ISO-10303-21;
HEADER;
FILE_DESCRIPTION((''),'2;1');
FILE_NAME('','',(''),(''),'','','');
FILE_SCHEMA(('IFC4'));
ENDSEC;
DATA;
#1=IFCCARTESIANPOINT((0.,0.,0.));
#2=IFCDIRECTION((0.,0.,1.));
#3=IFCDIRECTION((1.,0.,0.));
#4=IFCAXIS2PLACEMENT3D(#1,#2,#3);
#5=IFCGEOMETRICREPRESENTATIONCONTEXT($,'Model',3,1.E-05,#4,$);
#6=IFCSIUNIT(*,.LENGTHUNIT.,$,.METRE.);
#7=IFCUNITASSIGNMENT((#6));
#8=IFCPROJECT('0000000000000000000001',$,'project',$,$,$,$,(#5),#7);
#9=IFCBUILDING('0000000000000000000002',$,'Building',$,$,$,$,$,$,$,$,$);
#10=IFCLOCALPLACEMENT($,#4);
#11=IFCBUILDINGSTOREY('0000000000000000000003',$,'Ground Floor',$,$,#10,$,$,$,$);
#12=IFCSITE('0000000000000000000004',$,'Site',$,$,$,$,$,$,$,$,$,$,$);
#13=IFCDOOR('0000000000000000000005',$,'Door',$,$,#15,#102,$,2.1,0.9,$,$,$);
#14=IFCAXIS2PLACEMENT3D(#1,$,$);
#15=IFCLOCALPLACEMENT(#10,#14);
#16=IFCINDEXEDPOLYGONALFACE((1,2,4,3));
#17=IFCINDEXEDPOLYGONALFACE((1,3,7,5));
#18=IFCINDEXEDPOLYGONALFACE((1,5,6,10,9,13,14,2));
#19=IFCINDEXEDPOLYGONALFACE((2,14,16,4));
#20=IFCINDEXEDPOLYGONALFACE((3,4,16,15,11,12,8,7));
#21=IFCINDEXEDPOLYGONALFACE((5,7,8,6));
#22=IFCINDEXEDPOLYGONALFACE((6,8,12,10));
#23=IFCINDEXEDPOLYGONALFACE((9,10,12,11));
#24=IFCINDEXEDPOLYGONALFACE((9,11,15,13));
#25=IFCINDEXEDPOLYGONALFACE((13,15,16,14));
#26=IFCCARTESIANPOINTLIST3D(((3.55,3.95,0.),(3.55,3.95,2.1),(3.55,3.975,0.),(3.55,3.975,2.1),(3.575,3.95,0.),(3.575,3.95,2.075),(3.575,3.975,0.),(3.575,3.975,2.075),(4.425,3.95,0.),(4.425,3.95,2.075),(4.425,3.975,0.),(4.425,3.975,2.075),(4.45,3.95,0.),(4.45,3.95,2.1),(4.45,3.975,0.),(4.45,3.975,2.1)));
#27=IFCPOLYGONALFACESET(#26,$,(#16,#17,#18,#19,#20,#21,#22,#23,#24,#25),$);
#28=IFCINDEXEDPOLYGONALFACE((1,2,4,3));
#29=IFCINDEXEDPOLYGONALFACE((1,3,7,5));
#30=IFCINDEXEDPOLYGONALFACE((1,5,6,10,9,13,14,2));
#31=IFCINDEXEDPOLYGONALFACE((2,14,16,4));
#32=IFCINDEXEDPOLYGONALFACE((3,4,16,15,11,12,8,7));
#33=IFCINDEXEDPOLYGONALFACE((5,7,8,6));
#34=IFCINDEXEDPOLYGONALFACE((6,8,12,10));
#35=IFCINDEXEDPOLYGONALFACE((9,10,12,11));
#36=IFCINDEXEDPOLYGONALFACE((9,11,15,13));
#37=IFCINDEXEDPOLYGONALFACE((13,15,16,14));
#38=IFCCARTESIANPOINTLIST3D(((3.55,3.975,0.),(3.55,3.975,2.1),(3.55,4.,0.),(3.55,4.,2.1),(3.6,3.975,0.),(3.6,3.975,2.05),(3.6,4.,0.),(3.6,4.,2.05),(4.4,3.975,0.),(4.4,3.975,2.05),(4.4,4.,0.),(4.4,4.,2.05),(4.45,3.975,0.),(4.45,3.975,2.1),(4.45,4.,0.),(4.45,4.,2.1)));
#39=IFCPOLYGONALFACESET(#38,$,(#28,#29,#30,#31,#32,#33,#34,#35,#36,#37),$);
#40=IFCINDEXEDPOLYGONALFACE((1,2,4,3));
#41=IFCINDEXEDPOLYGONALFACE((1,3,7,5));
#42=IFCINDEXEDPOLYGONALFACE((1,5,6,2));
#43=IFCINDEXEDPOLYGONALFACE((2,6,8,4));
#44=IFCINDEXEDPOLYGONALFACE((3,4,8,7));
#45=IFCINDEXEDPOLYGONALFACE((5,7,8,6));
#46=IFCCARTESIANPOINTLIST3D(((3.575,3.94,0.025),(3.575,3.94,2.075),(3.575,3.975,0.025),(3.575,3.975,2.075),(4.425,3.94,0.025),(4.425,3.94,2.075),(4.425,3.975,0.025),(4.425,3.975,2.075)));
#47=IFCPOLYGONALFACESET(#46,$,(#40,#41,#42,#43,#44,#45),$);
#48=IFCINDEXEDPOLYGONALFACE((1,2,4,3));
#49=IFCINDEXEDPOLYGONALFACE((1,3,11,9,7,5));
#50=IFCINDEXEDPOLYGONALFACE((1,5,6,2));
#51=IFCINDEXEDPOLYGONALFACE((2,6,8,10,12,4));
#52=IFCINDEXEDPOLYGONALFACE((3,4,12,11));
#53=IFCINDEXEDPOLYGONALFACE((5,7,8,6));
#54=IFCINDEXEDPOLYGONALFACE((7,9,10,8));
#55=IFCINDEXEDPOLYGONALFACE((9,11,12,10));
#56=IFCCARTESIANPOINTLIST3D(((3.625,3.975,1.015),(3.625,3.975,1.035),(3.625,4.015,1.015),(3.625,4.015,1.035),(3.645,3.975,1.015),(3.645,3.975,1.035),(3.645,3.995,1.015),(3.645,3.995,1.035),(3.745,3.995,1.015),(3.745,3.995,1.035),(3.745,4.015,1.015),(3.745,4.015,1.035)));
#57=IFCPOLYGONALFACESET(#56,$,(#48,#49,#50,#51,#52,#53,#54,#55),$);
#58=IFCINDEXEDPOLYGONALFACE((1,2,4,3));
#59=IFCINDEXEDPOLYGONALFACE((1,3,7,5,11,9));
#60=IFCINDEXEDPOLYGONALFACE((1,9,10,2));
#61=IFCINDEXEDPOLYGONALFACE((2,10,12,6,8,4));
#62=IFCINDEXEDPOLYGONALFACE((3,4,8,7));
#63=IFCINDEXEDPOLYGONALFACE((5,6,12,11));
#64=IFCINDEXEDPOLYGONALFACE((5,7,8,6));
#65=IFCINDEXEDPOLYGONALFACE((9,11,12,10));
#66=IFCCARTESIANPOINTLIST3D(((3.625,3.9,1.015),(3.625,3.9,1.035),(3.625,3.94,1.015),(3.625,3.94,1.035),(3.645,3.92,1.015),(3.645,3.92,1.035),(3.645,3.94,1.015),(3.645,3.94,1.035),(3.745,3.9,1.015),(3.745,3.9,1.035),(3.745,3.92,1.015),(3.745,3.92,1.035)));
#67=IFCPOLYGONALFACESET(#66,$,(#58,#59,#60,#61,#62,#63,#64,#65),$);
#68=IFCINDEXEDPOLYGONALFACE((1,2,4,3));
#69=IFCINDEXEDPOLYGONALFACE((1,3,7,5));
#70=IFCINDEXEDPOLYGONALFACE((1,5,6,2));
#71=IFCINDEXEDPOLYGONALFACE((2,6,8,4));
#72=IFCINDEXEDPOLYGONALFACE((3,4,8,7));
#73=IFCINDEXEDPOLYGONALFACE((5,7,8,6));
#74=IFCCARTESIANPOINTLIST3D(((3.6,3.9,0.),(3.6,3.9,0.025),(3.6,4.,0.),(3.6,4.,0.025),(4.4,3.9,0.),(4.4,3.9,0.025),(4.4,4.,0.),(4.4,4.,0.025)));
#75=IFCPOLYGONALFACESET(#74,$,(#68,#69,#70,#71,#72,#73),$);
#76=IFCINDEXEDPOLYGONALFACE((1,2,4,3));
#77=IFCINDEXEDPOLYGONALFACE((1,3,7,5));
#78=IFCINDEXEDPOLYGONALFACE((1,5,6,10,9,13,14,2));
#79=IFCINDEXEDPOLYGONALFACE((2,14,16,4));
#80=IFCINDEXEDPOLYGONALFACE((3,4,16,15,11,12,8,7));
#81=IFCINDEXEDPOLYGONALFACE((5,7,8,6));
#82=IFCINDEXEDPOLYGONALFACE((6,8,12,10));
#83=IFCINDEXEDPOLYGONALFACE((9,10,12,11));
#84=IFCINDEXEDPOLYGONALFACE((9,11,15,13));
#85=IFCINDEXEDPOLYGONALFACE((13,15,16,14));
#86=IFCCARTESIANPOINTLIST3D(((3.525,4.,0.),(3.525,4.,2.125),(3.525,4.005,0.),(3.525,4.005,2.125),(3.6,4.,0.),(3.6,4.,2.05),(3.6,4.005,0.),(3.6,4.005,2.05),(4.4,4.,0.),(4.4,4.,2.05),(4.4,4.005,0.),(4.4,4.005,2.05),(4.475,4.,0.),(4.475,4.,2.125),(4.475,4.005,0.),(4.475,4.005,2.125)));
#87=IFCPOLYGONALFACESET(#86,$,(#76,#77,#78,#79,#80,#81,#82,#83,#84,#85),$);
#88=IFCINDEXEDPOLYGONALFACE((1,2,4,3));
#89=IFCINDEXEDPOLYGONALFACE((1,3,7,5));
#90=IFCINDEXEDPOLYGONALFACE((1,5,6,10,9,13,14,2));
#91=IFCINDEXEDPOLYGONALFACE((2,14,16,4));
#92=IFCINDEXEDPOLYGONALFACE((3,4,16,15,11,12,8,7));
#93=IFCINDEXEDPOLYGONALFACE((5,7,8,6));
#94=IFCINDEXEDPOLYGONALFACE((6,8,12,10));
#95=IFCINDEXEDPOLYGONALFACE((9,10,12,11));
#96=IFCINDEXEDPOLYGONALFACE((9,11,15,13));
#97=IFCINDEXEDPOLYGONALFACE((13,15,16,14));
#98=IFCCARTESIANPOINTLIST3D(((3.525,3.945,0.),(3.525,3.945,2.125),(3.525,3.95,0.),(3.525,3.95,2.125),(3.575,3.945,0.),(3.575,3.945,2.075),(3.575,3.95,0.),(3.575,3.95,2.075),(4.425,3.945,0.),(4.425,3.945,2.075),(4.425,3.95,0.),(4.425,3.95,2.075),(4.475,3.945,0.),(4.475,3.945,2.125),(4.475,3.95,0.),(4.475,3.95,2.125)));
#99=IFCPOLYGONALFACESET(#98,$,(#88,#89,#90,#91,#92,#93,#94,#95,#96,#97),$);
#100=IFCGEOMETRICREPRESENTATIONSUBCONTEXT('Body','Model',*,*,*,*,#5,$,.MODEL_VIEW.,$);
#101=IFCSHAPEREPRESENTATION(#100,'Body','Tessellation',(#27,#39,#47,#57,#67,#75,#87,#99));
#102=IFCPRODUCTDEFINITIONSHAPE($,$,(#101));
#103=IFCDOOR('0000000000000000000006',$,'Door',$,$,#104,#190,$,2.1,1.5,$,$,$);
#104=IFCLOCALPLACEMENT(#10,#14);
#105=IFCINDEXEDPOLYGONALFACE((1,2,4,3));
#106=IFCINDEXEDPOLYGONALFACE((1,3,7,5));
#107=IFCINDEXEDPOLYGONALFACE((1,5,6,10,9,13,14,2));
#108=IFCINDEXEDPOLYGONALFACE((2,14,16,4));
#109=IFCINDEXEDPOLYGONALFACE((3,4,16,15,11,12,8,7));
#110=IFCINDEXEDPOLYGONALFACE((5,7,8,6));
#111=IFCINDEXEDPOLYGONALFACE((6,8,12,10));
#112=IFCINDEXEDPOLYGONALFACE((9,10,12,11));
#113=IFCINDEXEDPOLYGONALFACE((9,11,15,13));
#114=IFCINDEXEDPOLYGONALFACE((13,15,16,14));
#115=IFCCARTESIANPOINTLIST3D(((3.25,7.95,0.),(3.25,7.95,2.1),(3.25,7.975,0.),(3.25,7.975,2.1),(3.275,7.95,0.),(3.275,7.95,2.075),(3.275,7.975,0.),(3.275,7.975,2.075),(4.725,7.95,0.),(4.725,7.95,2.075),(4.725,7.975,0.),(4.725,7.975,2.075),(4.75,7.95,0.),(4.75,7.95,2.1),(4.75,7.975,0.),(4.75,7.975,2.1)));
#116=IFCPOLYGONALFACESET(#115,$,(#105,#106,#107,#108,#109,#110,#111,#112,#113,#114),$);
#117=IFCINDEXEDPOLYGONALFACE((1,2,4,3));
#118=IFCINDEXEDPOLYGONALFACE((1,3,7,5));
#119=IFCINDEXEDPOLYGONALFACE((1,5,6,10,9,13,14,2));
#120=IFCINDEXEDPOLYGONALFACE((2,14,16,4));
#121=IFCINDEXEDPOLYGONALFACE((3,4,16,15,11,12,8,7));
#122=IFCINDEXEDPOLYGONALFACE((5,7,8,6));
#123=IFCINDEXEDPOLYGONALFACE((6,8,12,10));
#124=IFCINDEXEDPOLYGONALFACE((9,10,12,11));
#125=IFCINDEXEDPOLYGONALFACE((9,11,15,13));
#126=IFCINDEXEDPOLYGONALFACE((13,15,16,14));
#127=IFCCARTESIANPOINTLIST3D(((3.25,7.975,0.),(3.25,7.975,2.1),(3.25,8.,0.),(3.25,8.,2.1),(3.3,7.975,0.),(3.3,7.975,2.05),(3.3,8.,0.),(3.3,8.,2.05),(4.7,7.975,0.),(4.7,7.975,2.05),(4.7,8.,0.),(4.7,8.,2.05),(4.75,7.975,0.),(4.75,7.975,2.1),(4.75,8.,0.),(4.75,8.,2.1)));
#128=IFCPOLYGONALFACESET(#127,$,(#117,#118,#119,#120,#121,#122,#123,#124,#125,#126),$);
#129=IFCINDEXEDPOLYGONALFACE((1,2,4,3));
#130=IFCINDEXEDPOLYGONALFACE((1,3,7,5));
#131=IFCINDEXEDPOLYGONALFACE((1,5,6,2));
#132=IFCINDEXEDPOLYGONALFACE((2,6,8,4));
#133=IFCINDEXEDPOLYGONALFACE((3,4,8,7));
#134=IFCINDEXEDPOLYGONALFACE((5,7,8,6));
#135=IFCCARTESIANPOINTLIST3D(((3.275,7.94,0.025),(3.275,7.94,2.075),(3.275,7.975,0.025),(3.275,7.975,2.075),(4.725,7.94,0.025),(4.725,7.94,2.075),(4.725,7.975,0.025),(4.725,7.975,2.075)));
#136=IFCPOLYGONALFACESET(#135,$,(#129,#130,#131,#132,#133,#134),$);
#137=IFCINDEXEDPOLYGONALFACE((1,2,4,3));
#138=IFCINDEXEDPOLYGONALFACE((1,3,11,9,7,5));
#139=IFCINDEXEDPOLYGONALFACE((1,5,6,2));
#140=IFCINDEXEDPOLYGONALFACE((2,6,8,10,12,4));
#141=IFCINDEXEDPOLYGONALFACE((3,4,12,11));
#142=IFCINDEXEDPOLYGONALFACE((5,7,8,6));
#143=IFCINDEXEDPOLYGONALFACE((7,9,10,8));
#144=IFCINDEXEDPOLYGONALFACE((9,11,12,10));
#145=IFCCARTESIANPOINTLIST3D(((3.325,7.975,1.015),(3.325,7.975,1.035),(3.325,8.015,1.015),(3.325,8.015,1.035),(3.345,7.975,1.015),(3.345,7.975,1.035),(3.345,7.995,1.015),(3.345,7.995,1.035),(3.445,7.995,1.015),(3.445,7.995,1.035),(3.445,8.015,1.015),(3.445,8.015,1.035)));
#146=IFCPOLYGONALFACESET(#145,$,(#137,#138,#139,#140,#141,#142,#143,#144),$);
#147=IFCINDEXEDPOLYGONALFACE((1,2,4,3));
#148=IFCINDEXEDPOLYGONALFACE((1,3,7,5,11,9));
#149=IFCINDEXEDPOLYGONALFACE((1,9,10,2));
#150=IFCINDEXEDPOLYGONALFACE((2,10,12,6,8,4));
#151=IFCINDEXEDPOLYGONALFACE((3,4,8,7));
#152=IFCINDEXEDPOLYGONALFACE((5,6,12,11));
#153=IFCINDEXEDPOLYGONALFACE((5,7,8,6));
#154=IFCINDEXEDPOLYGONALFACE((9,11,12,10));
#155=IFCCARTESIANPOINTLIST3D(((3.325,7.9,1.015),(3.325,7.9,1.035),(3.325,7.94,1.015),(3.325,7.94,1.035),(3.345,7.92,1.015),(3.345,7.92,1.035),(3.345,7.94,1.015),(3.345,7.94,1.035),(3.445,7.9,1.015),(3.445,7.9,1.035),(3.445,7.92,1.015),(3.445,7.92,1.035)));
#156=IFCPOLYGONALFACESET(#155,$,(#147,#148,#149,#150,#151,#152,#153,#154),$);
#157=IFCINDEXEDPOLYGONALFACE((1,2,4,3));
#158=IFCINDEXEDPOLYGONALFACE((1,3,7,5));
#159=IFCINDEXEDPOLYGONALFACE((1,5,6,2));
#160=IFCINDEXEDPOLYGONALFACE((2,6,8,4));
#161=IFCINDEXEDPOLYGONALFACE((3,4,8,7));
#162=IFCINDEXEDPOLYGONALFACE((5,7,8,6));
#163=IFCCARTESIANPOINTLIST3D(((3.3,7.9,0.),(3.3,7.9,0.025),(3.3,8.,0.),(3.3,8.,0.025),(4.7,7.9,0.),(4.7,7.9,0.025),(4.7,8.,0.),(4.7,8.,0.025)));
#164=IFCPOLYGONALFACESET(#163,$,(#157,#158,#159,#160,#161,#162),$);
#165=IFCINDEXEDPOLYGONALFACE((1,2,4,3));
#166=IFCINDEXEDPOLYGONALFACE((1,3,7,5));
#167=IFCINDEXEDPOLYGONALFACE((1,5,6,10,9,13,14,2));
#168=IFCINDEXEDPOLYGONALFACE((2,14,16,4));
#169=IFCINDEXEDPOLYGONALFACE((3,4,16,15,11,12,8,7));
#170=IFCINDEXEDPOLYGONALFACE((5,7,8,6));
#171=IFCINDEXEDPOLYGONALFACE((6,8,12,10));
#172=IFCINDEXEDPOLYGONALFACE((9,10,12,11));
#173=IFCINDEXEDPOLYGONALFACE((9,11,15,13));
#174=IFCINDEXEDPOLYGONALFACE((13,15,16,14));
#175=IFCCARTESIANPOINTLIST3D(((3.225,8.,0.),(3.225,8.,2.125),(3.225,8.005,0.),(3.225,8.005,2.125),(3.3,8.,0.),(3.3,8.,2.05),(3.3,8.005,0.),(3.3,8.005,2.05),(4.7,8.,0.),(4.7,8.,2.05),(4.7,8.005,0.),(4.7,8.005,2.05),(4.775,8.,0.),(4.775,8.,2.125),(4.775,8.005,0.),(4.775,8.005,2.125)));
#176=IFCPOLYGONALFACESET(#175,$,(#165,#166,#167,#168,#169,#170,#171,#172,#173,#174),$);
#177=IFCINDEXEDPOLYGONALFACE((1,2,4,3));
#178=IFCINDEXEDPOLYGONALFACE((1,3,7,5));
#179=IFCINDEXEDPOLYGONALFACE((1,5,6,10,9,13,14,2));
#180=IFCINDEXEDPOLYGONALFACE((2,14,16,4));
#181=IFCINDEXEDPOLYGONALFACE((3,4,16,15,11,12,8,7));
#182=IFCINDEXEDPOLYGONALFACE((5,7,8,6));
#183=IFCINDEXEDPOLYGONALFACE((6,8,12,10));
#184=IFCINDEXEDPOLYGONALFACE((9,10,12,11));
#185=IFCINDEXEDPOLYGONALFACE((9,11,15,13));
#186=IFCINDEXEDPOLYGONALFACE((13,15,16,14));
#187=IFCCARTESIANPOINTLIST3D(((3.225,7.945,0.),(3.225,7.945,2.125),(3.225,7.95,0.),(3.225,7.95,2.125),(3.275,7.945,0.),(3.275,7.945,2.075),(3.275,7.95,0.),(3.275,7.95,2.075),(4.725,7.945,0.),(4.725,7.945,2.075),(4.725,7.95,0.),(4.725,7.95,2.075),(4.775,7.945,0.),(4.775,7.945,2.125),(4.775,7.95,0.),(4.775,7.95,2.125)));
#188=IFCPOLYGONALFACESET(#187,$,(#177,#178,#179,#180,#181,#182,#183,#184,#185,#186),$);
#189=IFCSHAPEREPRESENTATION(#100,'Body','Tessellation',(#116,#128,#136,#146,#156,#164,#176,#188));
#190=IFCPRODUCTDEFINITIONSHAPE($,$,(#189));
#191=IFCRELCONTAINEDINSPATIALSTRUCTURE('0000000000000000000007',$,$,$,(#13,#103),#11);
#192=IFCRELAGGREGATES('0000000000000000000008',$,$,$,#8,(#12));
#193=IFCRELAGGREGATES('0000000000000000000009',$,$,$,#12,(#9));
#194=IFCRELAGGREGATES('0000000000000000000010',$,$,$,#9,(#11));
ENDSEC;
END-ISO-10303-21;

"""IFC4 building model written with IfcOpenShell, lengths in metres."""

from ifc_helpers import new_model, si_unit, frame, origin_with_axes, place, context, subcontext, project, spatial, line, indexed_curve, outline, extrude, element, save


model = new_model("IFC4")

# Units and contexts
model_context = context("Model", 3, precision=1e-05, world=origin_with_axes())
body_context = subcontext(model_context, "Body", "Model", "MODEL_VIEW")
ifc_project = project(units=[si_unit("LENGTHUNIT", "METRE")], contexts=[model_context])

# Site, building, storey
site = spatial("IfcSite", under=ifc_project, Name="Site")
building = spatial("IfcBuilding", under=site, Name="Building")
storey_placement = place(None, origin_with_axes())
storey = spatial("IfcBuildingStorey", under=building, at=storey_placement, Name="Ground Floor")

# Doors
door_1_placement = place(storey_placement, frame((4.45, 4.0, 0.0), z_axis=(0.0, 0.0, 1.0), x_axis=(-1.0, 0.0, 0.0)))
element("IfcDoor", 1, at=door_1_placement, inside=storey, Name="Door", OverallHeight=2.1, OverallWidth=0.9, context=body_context, shape_type="SweptSolid", body=[
    extrude(outline(indexed_curve([(0.0, 0.0), (0.0, 2.1), (0.9, 2.1), (0.9, 0.0), (0.875, 0.0), (0.875, 2.075), (0.025, 2.075), (0.025, 0.0)], segments=[line(1, 2, 3, 4, 5, 6, 7, 8, 1)])), frame((0.0, 0.025, 0.0), z_axis=(0.0, -1.0, 0.0), x_axis=(1.0, 0.0, 0.0)), (0.0, 0.0, -1.0), 0.025),
    extrude(outline(indexed_curve([(0.0, 0.0), (0.0, 2.1), (0.9, 2.1), (0.9, 0.0), (0.85, 0.0), (0.85, 2.05), (0.05, 2.05), (0.05, 0.0)], segments=[line(1, 2, 3, 4, 5, 6, 7, 8, 1)])), frame((0.0, 0.0, 0.0), z_axis=(0.0, -1.0, 0.0), x_axis=(1.0, 0.0, 0.0)), (0.0, 0.0, -1.0), 0.025),
    extrude(outline(indexed_curve([(0.0, 0.0), (0.85, 0.0), (0.85, 0.035), (0.0, 0.035)], segments=[line(1, 2, 3, 4, 1)])), frame((0.025, 0.025, 0.025), z_axis=(0.0, 0.0, 1.0), x_axis=(1.0, 0.0, 0.0)), (0.0, 0.0, 1.0), 2.05),
    extrude(outline(indexed_curve([(0.0, 0.0), (0.0, -0.04), (-0.12, -0.04), (-0.12, -0.02), (-0.02, -0.02), (-0.02, 0.0)], segments=[line(1, 2, 3, 4, 5, 6, 1)])), frame((0.825, 0.025, 1.015), z_axis=(0.0, 0.0, 1.0), x_axis=(1.0, 0.0, 0.0)), (0.0, 0.0, 1.0), 0.02),
    extrude(outline(indexed_curve([(0.0, 0.0), (0.0, 0.04), (-0.12, 0.04), (-0.12, 0.02), (-0.02, 0.02), (-0.02, 0.0)], segments=[line(1, 2, 3, 4, 5, 6, 1)])), frame((0.825, 0.06, 1.015), z_axis=(0.0, 0.0, 1.0), x_axis=(1.0, 0.0, 0.0)), (0.0, 0.0, 1.0), 0.02),
    extrude(outline(indexed_curve([(0.0, 0.0), (0.8, 0.0), (0.8, 0.1), (0.0, 0.1)], segments=[line(1, 2, 3, 4, 1)])), frame((0.05, 0.0, 0.0), z_axis=(0.0, 0.0, 1.0), x_axis=(1.0, 0.0, 0.0)), (0.0, 0.0, 1.0), 0.025),
    extrude(outline(indexed_curve([(0.0, 0.0), (0.0, 2.125), (0.95, 2.125), (0.95, 0.0), (0.875, 0.0), (0.875, 2.05), (0.075, 2.05), (0.075, 0.0)], segments=[line(1, 2, 3, 4, 5, 6, 7, 8, 1)])), frame((-0.025, -0.005, 0.0), z_axis=(0.0, -1.0, 0.0), x_axis=(1.0, 0.0, 0.0)), (0.0, 0.0, -1.0), 0.005),
    extrude(outline(indexed_curve([(0.0, 0.0), (0.0, 2.125), (0.95, 2.125), (0.95, 0.0), (0.9, 0.0), (0.9, 2.075), (0.05, 2.075), (0.05, 0.0)], segments=[line(1, 2, 3, 4, 5, 6, 7, 8, 1)])), frame((-0.025, 0.05, 0.0), z_axis=(0.0, -1.0, 0.0), x_axis=(1.0, 0.0, 0.0)), (0.0, 0.0, -1.0), 0.005),
])
door_2_placement = place(storey_placement, frame((4.75, 8.0, 0.0), z_axis=(0.0, 0.0, 1.0), x_axis=(-1.0, 0.0, 0.0)))
element("IfcDoor", 2, at=door_2_placement, inside=storey, Name="Door", OverallHeight=2.1, OverallWidth=1.5, context=body_context, shape_type="SweptSolid", body=[
    extrude(outline(indexed_curve([(0.0, 0.0), (0.0, 2.1), (1.5, 2.1), (1.5, 0.0), (1.475, 0.0), (1.475, 2.075), (0.025, 2.075), (0.025, 0.0)], segments=[line(1, 2, 3, 4, 5, 6, 7, 8, 1)])), frame((0.0, 0.025, 0.0), z_axis=(0.0, -1.0, 0.0), x_axis=(1.0, 0.0, 0.0)), (0.0, 0.0, -1.0), 0.025),
    extrude(outline(indexed_curve([(0.0, 0.0), (0.0, 2.1), (1.5, 2.1), (1.5, 0.0), (1.45, 0.0), (1.45, 2.05), (0.05, 2.05), (0.05, 0.0)], segments=[line(1, 2, 3, 4, 5, 6, 7, 8, 1)])), frame((0.0, 0.0, 0.0), z_axis=(0.0, -1.0, 0.0), x_axis=(1.0, 0.0, 0.0)), (0.0, 0.0, -1.0), 0.025),
    extrude(outline(indexed_curve([(0.0, 0.0), (1.45, 0.0), (1.45, 0.035), (0.0, 0.035)], segments=[line(1, 2, 3, 4, 1)])), frame((0.025, 0.025, 0.025), z_axis=(0.0, 0.0, 1.0), x_axis=(1.0, 0.0, 0.0)), (0.0, 0.0, 1.0), 2.05),
    extrude(outline(indexed_curve([(0.0, 0.0), (0.0, -0.04), (-0.12, -0.04), (-0.12, -0.02), (-0.02, -0.02), (-0.02, 0.0)], segments=[line(1, 2, 3, 4, 5, 6, 1)])), frame((1.425, 0.025, 1.015), z_axis=(0.0, 0.0, 1.0), x_axis=(1.0, 0.0, 0.0)), (0.0, 0.0, 1.0), 0.02),
    extrude(outline(indexed_curve([(0.0, 0.0), (0.0, 0.04), (-0.12, 0.04), (-0.12, 0.02), (-0.02, 0.02), (-0.02, 0.0)], segments=[line(1, 2, 3, 4, 5, 6, 1)])), frame((1.425, 0.06, 1.015), z_axis=(0.0, 0.0, 1.0), x_axis=(1.0, 0.0, 0.0)), (0.0, 0.0, 1.0), 0.02),
    extrude(outline(indexed_curve([(0.0, 0.0), (1.4, 0.0), (1.4, 0.1), (0.0, 0.1)], segments=[line(1, 2, 3, 4, 1)])), frame((0.05, 0.0, 0.0), z_axis=(0.0, 0.0, 1.0), x_axis=(1.0, 0.0, 0.0)), (0.0, 0.0, 1.0), 0.025),
    extrude(outline(indexed_curve([(0.0, 0.0), (0.0, 2.125), (1.55, 2.125), (1.55, 0.0), (1.475, 0.0), (1.475, 2.05), (0.075, 2.05), (0.075, 0.0)], segments=[line(1, 2, 3, 4, 5, 6, 7, 8, 1)])), frame((-0.025, -0.005, 0.0), z_axis=(0.0, -1.0, 0.0), x_axis=(1.0, 0.0, 0.0)), (0.0, 0.0, -1.0), 0.005),
    extrude(outline(indexed_curve([(0.0, 0.0), (0.0, 2.125), (1.55, 2.125), (1.55, 0.0), (1.5, 0.0), (1.5, 2.075), (0.05, 2.075), (0.05, 0.0)], segments=[line(1, 2, 3, 4, 5, 6, 7, 8, 1)])), frame((-0.025, 0.05, 0.0), z_axis=(0.0, -1.0, 0.0), x_axis=(1.0, 0.0, 0.0)), (0.0, 0.0, -1.0), 0.005),
])

save(model, "model.ifc")
